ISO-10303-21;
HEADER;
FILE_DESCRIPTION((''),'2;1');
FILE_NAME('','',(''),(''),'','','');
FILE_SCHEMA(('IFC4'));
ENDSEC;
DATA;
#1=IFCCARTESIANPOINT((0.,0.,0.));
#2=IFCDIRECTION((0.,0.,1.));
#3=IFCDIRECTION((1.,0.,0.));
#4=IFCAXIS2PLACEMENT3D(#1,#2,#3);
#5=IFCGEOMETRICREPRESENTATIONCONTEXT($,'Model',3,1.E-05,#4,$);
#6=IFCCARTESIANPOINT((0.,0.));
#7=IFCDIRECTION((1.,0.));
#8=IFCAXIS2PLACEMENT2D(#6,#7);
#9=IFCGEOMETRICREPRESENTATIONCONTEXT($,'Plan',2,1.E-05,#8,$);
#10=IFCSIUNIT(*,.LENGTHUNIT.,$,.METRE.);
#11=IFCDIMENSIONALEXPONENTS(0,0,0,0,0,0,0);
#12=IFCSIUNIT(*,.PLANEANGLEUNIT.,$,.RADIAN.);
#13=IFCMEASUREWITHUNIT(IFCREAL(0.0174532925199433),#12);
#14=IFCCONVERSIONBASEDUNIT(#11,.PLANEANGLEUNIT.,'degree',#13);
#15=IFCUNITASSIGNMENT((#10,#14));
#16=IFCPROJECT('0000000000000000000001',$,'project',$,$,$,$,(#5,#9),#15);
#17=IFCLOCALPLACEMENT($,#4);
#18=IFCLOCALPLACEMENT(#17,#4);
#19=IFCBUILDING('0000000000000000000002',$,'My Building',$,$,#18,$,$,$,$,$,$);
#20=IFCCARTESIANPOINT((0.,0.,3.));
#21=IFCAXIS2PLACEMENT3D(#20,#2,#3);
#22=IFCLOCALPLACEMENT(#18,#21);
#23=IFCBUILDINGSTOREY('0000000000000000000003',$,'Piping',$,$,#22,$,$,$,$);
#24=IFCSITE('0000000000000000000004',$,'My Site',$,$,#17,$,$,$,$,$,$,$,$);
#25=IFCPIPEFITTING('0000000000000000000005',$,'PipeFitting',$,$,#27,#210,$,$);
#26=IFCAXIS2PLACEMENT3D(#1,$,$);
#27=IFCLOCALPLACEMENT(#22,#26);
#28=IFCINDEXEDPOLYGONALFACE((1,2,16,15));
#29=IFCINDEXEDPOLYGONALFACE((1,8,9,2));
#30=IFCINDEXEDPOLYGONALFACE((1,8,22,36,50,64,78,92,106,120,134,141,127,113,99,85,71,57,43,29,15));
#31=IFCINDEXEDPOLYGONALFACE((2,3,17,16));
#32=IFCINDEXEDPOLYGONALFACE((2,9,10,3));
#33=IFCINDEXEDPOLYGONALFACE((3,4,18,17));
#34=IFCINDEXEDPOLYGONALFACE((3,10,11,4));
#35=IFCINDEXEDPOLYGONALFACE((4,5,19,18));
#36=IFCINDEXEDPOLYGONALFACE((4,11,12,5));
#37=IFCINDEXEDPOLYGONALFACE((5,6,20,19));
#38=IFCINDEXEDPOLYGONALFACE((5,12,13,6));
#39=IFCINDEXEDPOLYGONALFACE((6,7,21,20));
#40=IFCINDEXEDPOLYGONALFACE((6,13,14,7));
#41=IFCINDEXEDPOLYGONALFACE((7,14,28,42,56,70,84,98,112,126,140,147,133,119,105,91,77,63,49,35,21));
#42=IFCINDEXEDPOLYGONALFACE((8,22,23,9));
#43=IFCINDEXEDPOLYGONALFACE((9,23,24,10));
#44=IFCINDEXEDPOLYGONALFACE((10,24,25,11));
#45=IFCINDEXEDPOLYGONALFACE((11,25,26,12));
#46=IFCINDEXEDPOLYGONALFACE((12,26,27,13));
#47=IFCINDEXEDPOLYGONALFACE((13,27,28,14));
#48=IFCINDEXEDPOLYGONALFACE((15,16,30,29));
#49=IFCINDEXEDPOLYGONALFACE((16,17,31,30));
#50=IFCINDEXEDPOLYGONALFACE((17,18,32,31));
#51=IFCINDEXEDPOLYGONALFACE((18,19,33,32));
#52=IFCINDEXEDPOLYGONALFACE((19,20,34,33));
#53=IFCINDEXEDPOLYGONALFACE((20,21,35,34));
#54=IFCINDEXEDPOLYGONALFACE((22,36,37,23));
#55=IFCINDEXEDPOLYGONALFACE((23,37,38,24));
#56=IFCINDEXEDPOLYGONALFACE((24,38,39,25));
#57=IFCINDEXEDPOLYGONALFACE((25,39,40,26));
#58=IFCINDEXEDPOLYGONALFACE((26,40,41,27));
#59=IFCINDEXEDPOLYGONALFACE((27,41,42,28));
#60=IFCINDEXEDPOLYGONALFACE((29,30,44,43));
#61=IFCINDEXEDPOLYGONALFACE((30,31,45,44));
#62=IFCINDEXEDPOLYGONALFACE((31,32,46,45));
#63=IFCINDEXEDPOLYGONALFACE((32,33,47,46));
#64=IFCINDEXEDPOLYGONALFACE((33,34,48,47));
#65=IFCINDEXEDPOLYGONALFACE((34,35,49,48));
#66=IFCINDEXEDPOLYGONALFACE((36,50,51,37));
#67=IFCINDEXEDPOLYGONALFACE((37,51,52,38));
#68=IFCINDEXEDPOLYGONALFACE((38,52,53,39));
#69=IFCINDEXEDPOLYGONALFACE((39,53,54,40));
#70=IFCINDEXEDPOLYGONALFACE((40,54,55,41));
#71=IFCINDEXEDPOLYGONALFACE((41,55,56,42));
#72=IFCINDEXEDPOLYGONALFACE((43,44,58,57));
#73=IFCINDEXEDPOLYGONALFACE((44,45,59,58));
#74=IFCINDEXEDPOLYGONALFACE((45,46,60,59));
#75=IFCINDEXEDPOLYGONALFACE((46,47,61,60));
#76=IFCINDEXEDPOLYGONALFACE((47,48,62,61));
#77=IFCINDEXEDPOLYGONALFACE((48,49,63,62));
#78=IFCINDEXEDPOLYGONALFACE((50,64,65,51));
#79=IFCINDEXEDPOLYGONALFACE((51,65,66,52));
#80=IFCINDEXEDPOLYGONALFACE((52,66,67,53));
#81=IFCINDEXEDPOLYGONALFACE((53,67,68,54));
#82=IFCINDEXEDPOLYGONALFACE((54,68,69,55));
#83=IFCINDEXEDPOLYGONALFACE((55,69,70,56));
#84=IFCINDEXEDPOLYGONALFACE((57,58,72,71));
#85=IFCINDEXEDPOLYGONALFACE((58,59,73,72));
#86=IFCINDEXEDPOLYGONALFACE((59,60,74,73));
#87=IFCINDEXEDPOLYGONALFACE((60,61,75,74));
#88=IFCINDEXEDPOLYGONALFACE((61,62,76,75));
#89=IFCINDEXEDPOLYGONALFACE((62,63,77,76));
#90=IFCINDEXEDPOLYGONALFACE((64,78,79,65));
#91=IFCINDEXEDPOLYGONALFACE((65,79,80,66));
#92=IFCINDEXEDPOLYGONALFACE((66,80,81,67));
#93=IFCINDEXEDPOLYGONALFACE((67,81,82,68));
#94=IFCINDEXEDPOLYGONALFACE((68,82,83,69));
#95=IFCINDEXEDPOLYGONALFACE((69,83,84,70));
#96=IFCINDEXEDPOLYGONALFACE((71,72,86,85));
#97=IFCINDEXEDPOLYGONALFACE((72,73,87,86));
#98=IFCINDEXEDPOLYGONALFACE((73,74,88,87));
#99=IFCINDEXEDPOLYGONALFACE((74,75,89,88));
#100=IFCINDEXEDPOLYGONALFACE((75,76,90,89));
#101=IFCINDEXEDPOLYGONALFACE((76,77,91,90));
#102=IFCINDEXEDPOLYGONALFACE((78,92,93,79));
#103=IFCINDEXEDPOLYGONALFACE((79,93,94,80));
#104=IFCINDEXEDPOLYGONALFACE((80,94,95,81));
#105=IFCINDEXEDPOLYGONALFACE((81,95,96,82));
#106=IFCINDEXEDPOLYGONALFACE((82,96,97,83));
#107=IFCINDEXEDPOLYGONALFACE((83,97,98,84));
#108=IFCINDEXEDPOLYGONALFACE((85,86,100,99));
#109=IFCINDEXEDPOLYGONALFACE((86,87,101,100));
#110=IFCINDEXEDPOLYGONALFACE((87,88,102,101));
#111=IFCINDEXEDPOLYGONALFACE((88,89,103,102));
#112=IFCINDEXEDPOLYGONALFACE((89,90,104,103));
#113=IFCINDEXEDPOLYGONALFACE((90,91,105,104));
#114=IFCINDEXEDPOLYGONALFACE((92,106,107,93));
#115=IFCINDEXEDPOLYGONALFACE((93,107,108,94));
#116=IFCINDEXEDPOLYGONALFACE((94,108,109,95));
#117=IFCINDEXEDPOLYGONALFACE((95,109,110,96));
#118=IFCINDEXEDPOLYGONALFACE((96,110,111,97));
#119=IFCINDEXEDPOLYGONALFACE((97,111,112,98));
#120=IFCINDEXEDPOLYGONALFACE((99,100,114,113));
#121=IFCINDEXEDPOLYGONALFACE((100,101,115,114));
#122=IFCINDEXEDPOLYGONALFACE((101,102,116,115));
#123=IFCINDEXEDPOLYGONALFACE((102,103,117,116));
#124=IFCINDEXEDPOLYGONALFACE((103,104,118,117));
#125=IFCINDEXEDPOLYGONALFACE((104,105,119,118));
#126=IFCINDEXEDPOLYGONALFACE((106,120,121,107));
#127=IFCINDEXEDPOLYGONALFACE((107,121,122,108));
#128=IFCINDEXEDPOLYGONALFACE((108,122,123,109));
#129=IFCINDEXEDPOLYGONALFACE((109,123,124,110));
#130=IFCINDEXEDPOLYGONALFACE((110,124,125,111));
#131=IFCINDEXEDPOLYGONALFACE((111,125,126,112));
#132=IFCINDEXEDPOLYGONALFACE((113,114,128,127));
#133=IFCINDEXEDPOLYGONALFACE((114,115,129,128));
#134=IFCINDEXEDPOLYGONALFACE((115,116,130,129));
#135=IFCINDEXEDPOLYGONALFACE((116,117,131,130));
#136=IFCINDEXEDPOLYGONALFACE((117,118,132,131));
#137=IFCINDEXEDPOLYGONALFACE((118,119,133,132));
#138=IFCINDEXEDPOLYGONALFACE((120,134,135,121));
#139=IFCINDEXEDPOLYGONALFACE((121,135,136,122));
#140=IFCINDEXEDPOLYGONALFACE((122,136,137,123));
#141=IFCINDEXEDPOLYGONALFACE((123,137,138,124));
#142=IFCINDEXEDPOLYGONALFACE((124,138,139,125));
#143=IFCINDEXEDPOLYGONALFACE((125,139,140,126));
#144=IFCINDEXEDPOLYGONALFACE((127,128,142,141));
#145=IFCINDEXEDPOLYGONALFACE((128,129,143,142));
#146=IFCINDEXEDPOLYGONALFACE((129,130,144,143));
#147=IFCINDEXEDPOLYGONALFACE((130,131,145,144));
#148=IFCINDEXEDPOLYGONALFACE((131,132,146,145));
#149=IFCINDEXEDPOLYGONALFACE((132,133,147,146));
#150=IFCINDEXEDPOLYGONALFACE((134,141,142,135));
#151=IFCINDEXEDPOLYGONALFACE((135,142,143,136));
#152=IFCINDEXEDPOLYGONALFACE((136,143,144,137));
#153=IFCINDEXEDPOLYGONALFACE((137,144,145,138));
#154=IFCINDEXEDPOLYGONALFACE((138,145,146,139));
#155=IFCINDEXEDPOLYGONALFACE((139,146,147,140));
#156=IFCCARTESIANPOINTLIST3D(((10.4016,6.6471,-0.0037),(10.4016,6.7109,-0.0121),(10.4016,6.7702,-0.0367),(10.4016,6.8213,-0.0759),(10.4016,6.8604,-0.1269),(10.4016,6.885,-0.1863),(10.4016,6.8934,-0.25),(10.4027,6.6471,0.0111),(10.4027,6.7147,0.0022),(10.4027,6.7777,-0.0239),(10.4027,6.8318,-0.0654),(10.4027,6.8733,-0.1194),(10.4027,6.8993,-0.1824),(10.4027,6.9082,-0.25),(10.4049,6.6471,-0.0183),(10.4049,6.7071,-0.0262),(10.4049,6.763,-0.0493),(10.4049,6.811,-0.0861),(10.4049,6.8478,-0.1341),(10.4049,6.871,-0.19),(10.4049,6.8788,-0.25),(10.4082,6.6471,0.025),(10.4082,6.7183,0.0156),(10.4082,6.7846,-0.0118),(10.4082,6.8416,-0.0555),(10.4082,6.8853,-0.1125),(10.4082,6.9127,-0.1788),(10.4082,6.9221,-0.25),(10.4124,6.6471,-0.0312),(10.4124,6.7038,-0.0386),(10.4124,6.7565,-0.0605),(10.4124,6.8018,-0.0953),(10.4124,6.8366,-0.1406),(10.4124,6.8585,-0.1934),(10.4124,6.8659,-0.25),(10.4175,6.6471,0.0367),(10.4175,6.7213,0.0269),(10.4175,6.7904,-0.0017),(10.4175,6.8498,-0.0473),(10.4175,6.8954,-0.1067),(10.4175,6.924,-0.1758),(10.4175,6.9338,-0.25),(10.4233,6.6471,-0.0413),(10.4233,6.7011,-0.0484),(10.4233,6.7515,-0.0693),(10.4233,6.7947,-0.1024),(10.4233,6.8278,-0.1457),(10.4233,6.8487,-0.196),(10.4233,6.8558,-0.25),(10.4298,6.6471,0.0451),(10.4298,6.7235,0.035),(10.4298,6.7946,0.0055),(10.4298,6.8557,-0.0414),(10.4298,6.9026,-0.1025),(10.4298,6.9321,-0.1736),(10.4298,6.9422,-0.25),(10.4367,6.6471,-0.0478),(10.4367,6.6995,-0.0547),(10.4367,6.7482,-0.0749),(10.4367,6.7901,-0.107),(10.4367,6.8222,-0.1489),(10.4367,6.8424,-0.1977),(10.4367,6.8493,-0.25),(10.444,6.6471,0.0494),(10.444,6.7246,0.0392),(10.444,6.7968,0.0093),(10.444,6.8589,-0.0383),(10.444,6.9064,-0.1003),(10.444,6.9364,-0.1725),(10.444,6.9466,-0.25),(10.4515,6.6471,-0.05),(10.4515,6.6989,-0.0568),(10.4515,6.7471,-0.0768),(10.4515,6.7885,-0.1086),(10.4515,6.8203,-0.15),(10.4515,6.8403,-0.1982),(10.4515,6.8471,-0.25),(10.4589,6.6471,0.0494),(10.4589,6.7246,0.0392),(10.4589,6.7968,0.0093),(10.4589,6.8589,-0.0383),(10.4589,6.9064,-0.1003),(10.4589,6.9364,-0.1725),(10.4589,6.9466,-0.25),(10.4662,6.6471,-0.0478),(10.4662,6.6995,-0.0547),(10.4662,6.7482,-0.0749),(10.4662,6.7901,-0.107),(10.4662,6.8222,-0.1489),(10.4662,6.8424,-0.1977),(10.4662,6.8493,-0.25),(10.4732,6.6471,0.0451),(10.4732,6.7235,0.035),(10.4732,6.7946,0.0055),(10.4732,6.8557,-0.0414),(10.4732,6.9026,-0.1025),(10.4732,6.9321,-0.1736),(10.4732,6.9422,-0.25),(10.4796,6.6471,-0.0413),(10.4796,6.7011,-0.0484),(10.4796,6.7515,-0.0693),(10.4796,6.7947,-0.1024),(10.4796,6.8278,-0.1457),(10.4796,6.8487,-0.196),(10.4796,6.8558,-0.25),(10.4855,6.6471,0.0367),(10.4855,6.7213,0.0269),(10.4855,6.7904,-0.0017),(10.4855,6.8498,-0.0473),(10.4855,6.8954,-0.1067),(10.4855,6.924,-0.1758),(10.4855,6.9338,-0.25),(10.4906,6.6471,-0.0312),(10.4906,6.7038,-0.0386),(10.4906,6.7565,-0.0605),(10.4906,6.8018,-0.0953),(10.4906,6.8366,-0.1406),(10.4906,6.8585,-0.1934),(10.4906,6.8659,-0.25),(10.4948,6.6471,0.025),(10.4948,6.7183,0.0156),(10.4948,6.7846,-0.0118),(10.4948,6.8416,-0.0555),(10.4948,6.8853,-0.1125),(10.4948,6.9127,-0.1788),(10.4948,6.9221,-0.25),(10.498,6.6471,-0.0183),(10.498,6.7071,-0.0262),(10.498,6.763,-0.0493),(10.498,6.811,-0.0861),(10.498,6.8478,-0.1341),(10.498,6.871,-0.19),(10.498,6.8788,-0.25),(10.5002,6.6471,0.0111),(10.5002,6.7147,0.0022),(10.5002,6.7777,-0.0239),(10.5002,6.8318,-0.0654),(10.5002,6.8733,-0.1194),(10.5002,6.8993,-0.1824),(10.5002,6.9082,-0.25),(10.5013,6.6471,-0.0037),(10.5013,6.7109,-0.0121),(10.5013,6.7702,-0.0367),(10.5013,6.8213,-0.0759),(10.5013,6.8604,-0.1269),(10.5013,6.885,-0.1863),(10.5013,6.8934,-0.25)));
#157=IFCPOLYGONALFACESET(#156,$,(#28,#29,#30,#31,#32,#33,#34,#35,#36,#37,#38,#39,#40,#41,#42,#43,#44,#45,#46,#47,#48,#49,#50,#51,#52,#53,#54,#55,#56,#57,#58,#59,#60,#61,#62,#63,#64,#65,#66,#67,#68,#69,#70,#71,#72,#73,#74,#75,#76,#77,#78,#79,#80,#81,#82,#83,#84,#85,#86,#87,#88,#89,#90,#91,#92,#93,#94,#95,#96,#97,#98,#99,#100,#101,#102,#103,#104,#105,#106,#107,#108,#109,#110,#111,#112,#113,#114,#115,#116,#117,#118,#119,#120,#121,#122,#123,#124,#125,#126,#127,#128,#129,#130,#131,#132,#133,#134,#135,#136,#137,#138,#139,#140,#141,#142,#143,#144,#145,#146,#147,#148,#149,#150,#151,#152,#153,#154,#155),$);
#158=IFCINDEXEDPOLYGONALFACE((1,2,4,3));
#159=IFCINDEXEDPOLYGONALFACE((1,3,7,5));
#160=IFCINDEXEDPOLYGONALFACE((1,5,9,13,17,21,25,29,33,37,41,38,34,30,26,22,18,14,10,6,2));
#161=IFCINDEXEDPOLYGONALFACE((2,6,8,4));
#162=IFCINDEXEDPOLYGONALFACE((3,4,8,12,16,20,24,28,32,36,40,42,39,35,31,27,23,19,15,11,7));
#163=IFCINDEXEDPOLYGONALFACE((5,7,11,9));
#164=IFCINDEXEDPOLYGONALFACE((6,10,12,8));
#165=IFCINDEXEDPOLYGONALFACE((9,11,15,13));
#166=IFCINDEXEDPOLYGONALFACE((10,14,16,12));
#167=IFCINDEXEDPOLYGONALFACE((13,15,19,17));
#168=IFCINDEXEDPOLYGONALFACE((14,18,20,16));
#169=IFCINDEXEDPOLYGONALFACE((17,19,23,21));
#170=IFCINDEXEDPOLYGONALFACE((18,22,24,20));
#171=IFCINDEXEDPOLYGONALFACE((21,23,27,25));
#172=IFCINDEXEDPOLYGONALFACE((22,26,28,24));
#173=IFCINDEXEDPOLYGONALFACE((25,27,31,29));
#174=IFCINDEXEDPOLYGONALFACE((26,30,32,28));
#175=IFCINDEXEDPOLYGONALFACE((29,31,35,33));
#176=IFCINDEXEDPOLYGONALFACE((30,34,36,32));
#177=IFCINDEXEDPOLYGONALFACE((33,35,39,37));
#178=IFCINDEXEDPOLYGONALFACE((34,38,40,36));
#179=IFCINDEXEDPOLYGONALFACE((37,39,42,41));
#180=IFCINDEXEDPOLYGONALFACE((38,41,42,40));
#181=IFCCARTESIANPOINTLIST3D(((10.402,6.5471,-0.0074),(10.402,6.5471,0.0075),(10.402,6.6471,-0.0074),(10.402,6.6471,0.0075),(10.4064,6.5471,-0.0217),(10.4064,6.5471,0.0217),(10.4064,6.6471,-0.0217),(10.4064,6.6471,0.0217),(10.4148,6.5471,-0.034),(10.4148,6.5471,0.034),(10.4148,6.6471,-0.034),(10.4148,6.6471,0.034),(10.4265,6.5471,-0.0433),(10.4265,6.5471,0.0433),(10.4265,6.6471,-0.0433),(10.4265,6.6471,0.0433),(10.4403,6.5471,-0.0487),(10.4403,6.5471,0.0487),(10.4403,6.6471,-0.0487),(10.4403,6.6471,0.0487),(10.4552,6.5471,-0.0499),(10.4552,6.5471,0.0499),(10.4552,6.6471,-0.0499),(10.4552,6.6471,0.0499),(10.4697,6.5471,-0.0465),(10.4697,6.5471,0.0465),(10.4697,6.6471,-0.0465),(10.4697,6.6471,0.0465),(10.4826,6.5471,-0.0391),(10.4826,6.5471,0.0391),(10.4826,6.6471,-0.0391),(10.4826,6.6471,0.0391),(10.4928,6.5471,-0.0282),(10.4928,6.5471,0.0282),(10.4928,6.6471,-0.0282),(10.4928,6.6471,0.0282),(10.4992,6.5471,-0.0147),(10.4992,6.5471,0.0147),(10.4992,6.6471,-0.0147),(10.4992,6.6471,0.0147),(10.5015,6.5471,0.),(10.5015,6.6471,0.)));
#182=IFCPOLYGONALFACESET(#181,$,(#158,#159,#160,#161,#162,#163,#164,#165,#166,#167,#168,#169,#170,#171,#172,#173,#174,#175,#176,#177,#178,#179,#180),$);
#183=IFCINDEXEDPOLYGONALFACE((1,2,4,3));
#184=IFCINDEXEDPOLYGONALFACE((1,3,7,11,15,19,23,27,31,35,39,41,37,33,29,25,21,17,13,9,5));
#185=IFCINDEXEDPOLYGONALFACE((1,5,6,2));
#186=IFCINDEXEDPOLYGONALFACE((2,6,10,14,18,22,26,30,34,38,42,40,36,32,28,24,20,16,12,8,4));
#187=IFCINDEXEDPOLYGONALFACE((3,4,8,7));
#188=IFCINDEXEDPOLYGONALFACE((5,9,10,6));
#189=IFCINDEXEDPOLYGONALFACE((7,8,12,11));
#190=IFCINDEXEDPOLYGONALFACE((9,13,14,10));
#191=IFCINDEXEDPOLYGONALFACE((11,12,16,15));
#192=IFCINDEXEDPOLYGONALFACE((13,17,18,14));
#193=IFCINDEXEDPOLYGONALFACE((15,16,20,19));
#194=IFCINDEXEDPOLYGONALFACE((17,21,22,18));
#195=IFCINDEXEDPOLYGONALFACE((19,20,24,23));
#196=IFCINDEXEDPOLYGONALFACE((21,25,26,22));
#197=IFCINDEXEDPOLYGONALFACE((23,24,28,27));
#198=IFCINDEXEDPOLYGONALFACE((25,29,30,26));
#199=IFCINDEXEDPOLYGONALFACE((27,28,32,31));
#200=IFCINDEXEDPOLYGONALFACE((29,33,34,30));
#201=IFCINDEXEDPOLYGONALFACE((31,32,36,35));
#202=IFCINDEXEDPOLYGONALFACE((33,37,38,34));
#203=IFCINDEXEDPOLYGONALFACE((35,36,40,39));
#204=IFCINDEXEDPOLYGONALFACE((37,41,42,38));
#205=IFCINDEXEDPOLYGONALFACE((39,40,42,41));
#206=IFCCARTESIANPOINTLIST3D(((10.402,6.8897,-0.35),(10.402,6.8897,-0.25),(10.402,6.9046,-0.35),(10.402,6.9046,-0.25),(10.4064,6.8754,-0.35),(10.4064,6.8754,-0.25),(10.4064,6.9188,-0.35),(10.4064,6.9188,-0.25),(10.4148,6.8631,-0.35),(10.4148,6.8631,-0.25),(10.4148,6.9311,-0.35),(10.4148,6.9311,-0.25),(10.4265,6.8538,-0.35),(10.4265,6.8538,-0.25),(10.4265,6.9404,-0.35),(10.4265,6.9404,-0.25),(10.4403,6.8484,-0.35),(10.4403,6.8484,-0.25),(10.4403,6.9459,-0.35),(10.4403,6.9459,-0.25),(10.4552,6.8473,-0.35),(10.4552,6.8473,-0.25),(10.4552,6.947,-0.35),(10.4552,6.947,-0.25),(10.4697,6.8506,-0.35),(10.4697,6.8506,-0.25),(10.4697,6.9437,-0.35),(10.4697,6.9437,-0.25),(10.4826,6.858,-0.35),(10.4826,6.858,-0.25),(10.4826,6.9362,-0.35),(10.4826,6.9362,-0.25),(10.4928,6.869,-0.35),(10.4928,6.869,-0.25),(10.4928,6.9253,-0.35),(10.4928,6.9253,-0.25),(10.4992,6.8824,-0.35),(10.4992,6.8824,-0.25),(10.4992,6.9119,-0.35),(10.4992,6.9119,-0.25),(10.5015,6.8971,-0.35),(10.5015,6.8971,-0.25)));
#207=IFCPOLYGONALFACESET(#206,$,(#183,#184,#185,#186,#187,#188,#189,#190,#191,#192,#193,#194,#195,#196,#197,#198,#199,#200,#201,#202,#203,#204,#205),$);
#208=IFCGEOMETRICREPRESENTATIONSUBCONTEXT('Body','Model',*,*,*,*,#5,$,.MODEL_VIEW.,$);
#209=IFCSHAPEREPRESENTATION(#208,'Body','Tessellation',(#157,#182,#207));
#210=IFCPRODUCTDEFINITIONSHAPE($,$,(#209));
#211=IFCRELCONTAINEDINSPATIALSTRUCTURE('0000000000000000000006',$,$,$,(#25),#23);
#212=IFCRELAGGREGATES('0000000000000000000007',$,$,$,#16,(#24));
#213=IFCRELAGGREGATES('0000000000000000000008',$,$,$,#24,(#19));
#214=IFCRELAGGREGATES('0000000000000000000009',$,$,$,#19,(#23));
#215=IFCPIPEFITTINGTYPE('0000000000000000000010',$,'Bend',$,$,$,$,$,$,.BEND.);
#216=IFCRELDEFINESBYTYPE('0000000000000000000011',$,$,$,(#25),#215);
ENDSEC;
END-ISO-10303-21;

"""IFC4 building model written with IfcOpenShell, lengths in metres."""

from ifc_helpers import new_model, entity, si_unit, converted_unit, frame, origin_with_axes, origin_2d_with_axis, place, context, subcontext, project, spatial, circle, extrude, source, transform, mapped, type_object, type_shapes, element, save


model = new_model("IFC4")

# Units and contexts
model_context = context("Model", 3, precision=1e-05, world=origin_with_axes())
plan_context = context("Plan", 2, precision=1e-05, world=origin_2d_with_axis())
body_context = subcontext(model_context, "Body", "Model", "MODEL_VIEW")
ifc_project = project(units=[si_unit("LENGTHUNIT", "METRE"), converted_unit("PLANEANGLEUNIT", "degree", entity("IfcReal", 0.0174532925199433), si_unit("PLANEANGLEUNIT", "RADIAN"), dimensions=[0, 0, 0, 0, 0, 0, 0])], contexts=[model_context, plan_context])

# Site, building, storey
site_placement = place(None, origin_with_axes())
site = spatial("IfcSite", under=ifc_project, at=site_placement, Name="My Site")
building_placement = place(site_placement, origin_with_axes())
building = spatial("IfcBuilding", under=site, at=building_placement, Name="My Building")
storey_placement = place(building_placement, frame((0.0, 0.0, 3.0), z_axis=(0.0, 0.0, 1.0), x_axis=(1.0, 0.0, 0.0)))
storey = spatial("IfcBuildingStorey", under=building, at=storey_placement, Name="Piping")

# Pipe fitting
pipe_fitting_type = type_object("IfcPipeFittingType", Name="Bend", PredefinedType="BEND")
shared_shape = source(origin_with_axes(), body_context, "Body", "SolidModel", [
    entity("IfcSweptDiskSolid", entity("IfcIndexedPolyCurve", entity("IfcCartesianPointList3D", [[0.0, 0.0, -0.1], [0.0, -0.0732, -0.2768], [0.0, -0.25, -0.35]]), [entity("IfcArcIndex", [1, 2, 3])]), 0.05),
    extrude(circle(Radius=0.05), origin_with_axes(), (0.0, 0.0, -1.0), 0.1),
    extrude(circle(Radius=0.05), frame((0.0, -0.25, -0.35), z_axis=(0.0, -1.0, 0.0), x_axis=(1.0, 0.0, 0.0)), (0.0, 0.0, 1.0), 0.1),
])
type_shapes(pipe_fitting_type, [shared_shape])
for number, where, z_axis, x_axis, name in (
    (1, (10.4515, 6.5471, 0.0), (0.0, -1.0, 0.0), (1.0, 0.0, 0.0), "PipeFitting"),
):
    element("IfcPipeFitting", number, at=place(storey_placement, frame(where, z_axis=z_axis, x_axis=x_axis)), inside=storey, type_object=pipe_fitting_type, Name=name, context=body_context, shape_type="MappedRepresentation", body=[
        mapped(shared_shape, transform((0.0, 0.0, 0.0), x_axis=(1.0, 0.0, 0.0), y_axis=(0.0, 1.0, 0.0), z_axis=(0.0, 0.0, 1.0), scale=1.0)),
    ])

save(model, "model.ifc")
